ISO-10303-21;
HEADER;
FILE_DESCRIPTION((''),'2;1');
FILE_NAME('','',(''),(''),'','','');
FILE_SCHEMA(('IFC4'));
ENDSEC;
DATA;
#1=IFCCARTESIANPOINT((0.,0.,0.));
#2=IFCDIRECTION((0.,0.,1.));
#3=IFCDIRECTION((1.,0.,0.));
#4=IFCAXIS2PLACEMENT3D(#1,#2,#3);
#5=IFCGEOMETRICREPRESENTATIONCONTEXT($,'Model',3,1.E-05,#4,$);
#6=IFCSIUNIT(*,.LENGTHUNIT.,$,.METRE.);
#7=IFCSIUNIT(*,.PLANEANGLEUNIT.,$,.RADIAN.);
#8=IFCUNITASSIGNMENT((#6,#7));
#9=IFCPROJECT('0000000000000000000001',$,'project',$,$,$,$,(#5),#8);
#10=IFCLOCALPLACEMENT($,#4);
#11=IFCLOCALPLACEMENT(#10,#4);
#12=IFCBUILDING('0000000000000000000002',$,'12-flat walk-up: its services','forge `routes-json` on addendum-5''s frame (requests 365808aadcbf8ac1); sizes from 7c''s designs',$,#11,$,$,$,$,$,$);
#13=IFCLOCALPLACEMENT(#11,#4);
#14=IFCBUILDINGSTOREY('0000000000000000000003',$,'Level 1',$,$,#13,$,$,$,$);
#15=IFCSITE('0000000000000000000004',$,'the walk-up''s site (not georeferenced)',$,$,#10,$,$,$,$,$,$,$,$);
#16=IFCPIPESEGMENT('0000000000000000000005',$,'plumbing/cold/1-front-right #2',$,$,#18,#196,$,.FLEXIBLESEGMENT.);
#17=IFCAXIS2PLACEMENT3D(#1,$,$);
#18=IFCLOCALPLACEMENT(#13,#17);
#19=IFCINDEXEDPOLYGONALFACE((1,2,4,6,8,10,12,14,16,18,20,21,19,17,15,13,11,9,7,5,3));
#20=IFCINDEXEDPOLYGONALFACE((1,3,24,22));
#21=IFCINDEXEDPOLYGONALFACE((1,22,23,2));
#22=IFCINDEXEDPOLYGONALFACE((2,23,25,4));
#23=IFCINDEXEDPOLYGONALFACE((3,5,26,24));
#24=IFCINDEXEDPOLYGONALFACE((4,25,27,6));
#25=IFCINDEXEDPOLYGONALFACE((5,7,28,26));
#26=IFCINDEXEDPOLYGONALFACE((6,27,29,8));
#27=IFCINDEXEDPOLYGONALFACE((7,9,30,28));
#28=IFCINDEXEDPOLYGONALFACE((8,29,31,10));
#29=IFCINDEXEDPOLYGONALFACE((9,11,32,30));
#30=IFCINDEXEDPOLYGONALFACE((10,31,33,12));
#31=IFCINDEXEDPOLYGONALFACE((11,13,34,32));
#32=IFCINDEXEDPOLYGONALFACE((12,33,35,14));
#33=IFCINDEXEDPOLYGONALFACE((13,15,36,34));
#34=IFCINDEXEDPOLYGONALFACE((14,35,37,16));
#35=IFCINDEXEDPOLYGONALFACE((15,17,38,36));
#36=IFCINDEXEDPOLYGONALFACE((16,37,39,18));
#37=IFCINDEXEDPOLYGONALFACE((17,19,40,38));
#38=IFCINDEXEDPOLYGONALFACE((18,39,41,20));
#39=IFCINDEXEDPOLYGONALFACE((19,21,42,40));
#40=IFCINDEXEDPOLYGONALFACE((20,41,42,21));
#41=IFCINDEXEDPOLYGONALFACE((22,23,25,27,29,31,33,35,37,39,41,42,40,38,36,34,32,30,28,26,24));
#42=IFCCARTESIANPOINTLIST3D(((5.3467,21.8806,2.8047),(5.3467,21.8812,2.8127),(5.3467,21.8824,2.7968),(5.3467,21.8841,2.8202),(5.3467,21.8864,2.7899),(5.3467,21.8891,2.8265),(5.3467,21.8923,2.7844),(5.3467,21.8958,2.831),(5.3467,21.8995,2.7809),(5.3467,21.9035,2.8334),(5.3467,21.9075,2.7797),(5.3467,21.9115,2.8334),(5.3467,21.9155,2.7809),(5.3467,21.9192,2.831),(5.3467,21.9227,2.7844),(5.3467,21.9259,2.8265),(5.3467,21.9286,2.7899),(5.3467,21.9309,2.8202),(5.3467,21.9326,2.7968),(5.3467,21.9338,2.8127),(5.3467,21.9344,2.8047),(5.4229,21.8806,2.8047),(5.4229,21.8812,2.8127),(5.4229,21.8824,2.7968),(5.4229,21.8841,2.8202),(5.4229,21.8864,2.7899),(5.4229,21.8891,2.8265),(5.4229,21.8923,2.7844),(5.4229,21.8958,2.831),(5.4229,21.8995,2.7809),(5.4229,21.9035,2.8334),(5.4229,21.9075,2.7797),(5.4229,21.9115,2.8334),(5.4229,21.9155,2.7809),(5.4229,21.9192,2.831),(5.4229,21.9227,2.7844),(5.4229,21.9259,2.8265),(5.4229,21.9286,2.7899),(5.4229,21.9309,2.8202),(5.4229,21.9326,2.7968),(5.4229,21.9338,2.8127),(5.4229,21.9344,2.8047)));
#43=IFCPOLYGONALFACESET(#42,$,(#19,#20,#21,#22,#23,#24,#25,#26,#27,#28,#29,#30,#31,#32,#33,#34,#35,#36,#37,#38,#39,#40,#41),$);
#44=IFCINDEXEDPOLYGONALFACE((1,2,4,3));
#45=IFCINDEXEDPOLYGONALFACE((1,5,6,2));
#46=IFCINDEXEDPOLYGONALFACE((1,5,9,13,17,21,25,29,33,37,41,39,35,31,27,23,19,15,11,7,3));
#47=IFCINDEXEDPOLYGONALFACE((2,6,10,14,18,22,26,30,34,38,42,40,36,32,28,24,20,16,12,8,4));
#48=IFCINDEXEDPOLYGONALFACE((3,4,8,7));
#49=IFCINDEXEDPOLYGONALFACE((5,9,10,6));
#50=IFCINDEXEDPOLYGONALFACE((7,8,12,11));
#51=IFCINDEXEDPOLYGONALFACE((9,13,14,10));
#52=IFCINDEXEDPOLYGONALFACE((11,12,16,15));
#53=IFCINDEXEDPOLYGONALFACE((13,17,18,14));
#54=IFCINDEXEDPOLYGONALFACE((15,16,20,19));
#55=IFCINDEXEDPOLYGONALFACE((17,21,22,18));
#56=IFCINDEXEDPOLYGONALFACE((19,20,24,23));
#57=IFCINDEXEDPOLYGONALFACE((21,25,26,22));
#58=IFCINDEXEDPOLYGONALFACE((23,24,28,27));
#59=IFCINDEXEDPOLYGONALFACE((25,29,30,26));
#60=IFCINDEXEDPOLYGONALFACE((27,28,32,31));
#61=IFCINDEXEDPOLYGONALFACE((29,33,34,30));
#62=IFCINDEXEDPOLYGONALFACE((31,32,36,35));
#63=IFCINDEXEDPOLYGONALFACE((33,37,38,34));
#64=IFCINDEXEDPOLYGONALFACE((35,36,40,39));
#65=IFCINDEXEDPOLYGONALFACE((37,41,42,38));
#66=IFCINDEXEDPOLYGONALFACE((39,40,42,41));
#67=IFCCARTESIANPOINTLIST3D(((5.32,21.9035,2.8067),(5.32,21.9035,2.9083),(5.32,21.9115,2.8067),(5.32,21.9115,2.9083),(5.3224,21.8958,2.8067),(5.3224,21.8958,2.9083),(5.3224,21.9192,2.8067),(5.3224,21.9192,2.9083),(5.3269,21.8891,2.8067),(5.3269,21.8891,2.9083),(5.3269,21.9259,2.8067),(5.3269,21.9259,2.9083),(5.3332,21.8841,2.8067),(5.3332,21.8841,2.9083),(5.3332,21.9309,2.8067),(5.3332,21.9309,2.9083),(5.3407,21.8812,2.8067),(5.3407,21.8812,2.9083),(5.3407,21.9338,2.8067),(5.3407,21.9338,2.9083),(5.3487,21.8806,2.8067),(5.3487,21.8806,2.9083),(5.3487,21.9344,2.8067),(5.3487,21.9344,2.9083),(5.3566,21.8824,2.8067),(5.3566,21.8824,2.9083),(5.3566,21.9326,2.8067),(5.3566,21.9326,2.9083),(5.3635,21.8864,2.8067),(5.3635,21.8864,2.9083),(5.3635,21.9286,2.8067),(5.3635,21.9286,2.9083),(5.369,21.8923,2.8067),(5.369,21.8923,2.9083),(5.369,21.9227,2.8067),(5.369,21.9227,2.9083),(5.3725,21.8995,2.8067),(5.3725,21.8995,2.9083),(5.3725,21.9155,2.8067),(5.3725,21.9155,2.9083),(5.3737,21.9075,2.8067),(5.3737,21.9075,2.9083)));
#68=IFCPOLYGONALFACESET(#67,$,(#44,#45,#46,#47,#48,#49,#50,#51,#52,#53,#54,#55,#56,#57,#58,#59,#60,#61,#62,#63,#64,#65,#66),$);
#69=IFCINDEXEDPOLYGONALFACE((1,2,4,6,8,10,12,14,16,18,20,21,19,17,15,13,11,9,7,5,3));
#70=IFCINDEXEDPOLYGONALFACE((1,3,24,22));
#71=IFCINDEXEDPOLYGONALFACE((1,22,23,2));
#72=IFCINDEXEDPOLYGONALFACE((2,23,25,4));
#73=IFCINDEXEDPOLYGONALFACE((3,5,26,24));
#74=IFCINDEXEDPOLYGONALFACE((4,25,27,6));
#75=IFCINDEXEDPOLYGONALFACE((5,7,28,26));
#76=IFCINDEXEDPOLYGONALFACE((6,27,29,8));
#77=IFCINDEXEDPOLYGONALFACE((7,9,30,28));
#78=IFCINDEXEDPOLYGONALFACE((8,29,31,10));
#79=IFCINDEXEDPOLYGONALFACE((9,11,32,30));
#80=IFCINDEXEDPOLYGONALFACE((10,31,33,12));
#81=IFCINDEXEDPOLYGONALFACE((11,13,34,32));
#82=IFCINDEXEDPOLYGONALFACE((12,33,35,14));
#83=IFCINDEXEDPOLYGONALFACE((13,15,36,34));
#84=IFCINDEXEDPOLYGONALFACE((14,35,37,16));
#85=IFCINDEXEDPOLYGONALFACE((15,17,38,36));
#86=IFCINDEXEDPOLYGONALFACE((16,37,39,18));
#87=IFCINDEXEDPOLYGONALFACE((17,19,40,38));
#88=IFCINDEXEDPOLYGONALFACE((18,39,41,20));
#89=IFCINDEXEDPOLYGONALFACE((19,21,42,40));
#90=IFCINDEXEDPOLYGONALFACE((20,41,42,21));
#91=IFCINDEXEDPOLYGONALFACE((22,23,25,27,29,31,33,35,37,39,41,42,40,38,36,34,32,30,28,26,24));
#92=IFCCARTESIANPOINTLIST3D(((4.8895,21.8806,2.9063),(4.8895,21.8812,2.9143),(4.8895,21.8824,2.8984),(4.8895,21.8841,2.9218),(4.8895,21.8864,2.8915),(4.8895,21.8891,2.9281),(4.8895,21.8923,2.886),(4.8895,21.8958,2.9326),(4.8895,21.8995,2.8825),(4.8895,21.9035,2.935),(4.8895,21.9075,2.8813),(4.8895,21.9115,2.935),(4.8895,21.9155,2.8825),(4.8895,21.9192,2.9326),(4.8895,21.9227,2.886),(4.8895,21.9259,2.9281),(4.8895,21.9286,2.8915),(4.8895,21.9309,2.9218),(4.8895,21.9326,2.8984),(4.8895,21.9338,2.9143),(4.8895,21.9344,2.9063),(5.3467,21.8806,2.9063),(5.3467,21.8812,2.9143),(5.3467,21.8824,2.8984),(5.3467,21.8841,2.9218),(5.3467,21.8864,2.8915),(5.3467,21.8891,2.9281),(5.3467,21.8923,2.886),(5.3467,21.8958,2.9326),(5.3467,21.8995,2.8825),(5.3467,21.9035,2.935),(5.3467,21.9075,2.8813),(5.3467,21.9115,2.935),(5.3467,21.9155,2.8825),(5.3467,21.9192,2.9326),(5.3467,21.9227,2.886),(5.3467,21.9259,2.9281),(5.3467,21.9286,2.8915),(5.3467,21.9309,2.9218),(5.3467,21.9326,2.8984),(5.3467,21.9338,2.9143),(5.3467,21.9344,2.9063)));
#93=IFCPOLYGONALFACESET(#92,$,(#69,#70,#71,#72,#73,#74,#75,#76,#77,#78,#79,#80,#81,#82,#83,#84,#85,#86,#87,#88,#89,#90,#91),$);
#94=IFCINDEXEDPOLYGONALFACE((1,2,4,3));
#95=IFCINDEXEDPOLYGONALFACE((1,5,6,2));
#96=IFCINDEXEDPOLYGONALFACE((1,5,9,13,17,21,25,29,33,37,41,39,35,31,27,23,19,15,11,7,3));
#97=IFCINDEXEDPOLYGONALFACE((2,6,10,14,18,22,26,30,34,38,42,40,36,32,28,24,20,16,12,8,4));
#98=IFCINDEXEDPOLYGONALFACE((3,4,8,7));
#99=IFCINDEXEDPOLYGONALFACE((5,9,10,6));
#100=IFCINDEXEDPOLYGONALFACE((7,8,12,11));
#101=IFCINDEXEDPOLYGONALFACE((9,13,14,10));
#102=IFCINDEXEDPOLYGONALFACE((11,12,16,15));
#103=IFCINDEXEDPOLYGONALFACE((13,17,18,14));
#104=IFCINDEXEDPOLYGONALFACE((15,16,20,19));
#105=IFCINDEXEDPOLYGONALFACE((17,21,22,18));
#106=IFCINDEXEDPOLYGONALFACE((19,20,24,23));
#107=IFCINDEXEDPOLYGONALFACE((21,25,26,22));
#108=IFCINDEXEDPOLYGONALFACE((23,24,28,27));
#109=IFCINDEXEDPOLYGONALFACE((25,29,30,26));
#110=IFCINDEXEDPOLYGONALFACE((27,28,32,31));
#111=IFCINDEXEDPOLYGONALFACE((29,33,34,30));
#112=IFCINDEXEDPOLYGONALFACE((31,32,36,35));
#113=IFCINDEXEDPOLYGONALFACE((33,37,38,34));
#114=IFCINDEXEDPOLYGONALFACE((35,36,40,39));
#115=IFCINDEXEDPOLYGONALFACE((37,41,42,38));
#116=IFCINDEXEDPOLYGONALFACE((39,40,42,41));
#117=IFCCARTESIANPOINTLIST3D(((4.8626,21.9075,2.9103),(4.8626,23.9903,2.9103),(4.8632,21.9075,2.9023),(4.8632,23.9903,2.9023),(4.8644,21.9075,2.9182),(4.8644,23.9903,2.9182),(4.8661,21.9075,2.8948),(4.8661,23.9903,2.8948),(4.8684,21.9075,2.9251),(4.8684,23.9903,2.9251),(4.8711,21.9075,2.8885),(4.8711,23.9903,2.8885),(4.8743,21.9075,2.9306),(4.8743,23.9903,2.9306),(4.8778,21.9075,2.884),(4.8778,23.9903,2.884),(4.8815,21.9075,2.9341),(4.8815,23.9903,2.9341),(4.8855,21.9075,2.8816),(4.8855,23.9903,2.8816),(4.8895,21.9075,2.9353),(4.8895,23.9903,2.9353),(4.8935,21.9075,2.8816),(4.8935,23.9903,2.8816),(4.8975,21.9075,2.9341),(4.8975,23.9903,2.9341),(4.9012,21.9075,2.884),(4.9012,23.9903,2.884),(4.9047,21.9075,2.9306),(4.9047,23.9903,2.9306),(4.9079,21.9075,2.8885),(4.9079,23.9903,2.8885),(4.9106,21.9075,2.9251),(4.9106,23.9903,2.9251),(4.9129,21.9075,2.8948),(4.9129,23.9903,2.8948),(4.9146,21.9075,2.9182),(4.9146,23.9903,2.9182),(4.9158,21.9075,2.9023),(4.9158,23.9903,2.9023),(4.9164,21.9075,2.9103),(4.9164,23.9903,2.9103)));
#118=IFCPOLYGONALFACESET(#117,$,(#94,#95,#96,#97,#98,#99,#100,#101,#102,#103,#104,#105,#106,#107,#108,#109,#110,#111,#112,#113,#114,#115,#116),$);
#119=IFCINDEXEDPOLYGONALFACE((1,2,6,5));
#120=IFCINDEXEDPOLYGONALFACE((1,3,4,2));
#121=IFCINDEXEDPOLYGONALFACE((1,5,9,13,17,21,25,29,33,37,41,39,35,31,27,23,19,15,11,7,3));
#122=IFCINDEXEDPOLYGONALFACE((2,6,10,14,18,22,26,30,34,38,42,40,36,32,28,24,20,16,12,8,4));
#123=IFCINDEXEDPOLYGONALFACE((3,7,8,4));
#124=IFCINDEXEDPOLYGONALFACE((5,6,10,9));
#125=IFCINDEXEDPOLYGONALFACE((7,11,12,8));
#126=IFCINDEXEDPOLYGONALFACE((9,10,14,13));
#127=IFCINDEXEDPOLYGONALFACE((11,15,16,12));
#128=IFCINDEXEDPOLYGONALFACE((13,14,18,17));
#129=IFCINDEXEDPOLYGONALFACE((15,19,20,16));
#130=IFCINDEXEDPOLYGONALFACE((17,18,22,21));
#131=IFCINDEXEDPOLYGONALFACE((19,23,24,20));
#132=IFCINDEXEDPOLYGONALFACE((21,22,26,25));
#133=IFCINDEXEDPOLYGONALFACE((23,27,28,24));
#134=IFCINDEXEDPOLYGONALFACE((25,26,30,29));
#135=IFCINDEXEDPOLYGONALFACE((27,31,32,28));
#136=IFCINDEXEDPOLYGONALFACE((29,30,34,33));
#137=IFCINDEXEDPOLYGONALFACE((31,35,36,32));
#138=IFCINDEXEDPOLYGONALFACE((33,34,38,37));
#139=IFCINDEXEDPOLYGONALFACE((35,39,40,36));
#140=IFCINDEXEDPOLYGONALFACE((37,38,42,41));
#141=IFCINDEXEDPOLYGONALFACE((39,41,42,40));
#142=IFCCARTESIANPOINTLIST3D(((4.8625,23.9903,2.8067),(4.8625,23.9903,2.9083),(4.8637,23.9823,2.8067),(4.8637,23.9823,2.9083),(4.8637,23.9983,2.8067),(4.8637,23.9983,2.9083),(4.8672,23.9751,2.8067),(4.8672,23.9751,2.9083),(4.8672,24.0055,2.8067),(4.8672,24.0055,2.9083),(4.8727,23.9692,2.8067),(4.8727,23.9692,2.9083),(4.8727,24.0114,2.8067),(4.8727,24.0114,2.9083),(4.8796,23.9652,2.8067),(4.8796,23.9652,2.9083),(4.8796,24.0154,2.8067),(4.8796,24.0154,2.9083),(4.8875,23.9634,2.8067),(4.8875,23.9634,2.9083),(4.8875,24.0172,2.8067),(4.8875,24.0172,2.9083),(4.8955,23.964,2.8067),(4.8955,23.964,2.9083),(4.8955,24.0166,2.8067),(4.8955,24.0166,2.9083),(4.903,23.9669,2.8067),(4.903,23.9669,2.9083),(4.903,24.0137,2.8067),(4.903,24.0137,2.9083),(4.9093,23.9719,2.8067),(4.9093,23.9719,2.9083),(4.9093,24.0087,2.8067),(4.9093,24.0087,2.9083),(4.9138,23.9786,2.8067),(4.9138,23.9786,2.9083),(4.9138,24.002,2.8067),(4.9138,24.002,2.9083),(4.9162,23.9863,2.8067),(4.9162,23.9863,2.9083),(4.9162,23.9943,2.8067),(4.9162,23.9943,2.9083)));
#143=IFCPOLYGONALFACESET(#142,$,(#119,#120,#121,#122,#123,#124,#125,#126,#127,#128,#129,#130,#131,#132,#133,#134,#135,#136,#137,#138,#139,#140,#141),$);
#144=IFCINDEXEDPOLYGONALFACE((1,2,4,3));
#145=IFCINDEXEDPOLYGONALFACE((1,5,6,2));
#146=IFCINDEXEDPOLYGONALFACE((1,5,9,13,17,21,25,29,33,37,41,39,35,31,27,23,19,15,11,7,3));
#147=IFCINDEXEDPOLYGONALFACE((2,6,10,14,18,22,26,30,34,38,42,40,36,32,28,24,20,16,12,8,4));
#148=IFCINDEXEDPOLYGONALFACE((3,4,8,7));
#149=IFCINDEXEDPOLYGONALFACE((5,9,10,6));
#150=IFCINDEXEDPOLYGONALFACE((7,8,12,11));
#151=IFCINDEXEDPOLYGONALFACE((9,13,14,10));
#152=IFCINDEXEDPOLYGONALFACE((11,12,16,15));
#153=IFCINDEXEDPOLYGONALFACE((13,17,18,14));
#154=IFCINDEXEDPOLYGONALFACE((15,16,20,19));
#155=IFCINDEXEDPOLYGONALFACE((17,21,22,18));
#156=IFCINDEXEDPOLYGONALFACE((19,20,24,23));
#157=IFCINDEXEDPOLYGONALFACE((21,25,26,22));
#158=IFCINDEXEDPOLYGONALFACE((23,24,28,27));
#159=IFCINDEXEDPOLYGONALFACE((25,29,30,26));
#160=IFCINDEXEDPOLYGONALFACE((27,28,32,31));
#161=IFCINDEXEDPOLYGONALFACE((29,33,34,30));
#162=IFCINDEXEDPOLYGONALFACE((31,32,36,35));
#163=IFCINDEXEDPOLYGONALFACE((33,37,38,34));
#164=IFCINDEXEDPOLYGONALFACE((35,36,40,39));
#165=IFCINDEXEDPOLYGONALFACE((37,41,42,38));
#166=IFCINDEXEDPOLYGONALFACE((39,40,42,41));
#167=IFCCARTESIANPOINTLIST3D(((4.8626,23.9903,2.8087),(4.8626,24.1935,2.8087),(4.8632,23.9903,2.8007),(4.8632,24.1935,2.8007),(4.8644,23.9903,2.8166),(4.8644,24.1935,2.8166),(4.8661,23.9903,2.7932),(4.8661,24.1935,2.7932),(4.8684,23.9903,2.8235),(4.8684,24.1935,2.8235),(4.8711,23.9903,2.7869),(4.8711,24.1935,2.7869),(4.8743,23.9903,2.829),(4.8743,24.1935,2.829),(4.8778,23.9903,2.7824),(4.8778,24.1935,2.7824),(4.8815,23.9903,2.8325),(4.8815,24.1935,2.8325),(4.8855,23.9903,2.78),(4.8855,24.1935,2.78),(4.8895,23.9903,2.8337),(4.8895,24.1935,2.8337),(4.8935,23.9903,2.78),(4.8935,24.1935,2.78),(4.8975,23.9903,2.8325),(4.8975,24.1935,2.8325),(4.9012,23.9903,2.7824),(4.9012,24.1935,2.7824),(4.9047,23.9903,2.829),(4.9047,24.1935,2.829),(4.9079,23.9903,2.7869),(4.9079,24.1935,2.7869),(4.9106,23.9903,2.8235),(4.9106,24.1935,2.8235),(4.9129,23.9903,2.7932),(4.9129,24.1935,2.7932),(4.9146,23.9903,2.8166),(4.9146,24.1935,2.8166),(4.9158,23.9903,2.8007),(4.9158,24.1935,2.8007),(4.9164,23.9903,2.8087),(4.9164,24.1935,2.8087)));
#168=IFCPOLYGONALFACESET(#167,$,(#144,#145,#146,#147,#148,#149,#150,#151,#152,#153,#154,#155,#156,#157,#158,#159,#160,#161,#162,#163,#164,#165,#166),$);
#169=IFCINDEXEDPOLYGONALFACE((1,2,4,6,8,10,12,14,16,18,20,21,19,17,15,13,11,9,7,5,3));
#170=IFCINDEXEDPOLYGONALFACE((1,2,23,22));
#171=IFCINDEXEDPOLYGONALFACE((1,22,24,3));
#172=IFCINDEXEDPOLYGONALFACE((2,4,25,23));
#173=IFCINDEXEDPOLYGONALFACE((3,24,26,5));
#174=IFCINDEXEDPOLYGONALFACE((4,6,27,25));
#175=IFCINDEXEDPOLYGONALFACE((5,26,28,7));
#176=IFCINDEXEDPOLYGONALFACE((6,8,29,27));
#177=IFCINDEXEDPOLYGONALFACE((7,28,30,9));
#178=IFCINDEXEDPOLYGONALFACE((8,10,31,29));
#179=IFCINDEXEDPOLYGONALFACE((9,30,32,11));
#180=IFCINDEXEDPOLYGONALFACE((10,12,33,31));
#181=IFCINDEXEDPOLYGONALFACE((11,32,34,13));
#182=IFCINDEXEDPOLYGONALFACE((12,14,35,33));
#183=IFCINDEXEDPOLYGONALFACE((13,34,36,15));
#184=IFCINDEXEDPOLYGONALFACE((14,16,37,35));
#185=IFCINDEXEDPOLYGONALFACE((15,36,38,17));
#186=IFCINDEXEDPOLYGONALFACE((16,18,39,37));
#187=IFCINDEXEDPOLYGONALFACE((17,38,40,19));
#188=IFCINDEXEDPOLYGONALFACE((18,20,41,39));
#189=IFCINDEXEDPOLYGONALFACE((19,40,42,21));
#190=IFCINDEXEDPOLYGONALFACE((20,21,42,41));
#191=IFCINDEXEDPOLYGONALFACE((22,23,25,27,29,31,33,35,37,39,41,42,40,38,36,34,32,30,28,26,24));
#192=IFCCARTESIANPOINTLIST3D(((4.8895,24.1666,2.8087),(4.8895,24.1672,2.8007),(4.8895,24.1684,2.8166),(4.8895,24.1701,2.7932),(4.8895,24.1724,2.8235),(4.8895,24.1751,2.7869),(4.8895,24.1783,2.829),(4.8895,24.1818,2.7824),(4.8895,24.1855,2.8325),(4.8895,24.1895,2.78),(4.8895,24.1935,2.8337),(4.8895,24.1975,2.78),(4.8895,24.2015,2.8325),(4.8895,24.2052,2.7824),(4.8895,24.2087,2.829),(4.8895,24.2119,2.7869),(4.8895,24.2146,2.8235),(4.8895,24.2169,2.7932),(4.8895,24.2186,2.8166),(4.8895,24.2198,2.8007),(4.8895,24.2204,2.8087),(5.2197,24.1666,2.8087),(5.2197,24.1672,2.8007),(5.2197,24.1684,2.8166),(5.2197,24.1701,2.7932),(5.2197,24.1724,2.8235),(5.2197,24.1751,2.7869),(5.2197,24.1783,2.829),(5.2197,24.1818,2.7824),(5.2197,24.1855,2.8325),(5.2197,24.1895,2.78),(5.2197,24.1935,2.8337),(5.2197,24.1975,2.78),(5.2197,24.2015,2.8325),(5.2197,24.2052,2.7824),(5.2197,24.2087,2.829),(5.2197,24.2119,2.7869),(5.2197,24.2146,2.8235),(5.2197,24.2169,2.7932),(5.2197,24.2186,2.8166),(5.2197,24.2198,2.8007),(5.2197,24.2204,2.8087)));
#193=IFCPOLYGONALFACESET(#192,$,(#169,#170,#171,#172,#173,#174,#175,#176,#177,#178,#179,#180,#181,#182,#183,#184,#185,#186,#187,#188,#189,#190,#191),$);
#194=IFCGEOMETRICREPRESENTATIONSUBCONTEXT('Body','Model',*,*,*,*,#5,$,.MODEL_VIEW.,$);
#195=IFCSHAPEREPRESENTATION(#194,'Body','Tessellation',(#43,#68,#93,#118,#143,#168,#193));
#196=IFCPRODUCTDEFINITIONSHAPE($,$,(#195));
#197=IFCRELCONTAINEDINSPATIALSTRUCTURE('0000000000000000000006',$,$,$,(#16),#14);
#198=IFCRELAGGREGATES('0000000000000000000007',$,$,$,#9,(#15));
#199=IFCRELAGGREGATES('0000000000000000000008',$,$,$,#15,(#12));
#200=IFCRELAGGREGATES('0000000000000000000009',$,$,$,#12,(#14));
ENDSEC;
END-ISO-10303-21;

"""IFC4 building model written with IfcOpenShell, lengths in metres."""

from ifc_helpers import new_model, entity, si_unit, frame, origin_with_axes, place, context, subcontext, project, spatial, element, save


model = new_model("IFC4")

# Units and contexts
model_context = context("Model", 3, precision=1e-05, world=origin_with_axes())
body_context = subcontext(model_context, "Body", "Model", "MODEL_VIEW")
ifc_project = project(units=[si_unit("LENGTHUNIT", "METRE"), si_unit("PLANEANGLEUNIT", "RADIAN")], contexts=[model_context])

# Site, building, storey
site_placement = place(None, origin_with_axes())
site = spatial("IfcSite", under=ifc_project, at=site_placement, Name="the walk-up's site (not georeferenced)")
building_placement = place(site_placement, origin_with_axes())
building = spatial("IfcBuilding", under=site, at=building_placement, Name="12-flat walk-up: its services", Description="forge `routes-json` on addendum-5's frame (requests 365808aadcbf8ac1); sizes from 7c's designs")
storey_placement = place(building_placement, origin_with_axes())
storey = spatial("IfcBuildingStorey", under=building, at=storey_placement, Name="Level 1")

# Pipe segment
pipe_segment_1_placement = place(storey_placement, frame((5.4229, 21.9075, 2.8067), z_axis=(0.0, 0.0, 1.0), x_axis=(1.0, 0.0, 0.0)))
element("IfcPipeSegment", 1, at=pipe_segment_1_placement, inside=storey, Name="plumbing/cold/1-front-right #2", PredefinedType="FLEXIBLESEGMENT", context=body_context, shape_type="AdvancedSweptSolid", body=[
    entity("IfcSweptDiskSolid", entity("IfcPolyline", [entity("IfcCartesianPoint", [0.0, 0.0, 0.0]), entity("IfcCartesianPoint", [-0.0762, 0.0, 0.0])]), 0.027),
    entity("IfcSweptDiskSolid", entity("IfcPolyline", [entity("IfcCartesianPoint", [-0.0762, 0.0, 0.0]), entity("IfcCartesianPoint", [-0.0762, 0.0, 0.1016])]), 0.027),
    entity("IfcSweptDiskSolid", entity("IfcPolyline", [entity("IfcCartesianPoint", [-0.0762, 0.0, 0.1016]), entity("IfcCartesianPoint", [-0.5334, 0.0, 0.1016])]), 0.027),
    entity("IfcSweptDiskSolid", entity("IfcPolyline", [entity("IfcCartesianPoint", [-0.5334, 0.0, 0.1016]), entity("IfcCartesianPoint", [-0.5334, 2.0828, 0.1016])]), 0.027),
    entity("IfcSweptDiskSolid", entity("IfcPolyline", [entity("IfcCartesianPoint", [-0.5334, 2.0828, 0.1016]), entity("IfcCartesianPoint", [-0.5334, 2.0828, 0.0])]), 0.027),
    entity("IfcSweptDiskSolid", entity("IfcPolyline", [entity("IfcCartesianPoint", [-0.5334, 2.0828, 0.0]), entity("IfcCartesianPoint", [-0.5334, 2.286, 0.0])]), 0.027),
    entity("IfcSweptDiskSolid", entity("IfcPolyline", [entity("IfcCartesianPoint", [-0.5334, 2.286, 0.0]), entity("IfcCartesianPoint", [-0.2032, 2.286, 0.0])]), 0.027),
])

save(model, "model.ifc")
